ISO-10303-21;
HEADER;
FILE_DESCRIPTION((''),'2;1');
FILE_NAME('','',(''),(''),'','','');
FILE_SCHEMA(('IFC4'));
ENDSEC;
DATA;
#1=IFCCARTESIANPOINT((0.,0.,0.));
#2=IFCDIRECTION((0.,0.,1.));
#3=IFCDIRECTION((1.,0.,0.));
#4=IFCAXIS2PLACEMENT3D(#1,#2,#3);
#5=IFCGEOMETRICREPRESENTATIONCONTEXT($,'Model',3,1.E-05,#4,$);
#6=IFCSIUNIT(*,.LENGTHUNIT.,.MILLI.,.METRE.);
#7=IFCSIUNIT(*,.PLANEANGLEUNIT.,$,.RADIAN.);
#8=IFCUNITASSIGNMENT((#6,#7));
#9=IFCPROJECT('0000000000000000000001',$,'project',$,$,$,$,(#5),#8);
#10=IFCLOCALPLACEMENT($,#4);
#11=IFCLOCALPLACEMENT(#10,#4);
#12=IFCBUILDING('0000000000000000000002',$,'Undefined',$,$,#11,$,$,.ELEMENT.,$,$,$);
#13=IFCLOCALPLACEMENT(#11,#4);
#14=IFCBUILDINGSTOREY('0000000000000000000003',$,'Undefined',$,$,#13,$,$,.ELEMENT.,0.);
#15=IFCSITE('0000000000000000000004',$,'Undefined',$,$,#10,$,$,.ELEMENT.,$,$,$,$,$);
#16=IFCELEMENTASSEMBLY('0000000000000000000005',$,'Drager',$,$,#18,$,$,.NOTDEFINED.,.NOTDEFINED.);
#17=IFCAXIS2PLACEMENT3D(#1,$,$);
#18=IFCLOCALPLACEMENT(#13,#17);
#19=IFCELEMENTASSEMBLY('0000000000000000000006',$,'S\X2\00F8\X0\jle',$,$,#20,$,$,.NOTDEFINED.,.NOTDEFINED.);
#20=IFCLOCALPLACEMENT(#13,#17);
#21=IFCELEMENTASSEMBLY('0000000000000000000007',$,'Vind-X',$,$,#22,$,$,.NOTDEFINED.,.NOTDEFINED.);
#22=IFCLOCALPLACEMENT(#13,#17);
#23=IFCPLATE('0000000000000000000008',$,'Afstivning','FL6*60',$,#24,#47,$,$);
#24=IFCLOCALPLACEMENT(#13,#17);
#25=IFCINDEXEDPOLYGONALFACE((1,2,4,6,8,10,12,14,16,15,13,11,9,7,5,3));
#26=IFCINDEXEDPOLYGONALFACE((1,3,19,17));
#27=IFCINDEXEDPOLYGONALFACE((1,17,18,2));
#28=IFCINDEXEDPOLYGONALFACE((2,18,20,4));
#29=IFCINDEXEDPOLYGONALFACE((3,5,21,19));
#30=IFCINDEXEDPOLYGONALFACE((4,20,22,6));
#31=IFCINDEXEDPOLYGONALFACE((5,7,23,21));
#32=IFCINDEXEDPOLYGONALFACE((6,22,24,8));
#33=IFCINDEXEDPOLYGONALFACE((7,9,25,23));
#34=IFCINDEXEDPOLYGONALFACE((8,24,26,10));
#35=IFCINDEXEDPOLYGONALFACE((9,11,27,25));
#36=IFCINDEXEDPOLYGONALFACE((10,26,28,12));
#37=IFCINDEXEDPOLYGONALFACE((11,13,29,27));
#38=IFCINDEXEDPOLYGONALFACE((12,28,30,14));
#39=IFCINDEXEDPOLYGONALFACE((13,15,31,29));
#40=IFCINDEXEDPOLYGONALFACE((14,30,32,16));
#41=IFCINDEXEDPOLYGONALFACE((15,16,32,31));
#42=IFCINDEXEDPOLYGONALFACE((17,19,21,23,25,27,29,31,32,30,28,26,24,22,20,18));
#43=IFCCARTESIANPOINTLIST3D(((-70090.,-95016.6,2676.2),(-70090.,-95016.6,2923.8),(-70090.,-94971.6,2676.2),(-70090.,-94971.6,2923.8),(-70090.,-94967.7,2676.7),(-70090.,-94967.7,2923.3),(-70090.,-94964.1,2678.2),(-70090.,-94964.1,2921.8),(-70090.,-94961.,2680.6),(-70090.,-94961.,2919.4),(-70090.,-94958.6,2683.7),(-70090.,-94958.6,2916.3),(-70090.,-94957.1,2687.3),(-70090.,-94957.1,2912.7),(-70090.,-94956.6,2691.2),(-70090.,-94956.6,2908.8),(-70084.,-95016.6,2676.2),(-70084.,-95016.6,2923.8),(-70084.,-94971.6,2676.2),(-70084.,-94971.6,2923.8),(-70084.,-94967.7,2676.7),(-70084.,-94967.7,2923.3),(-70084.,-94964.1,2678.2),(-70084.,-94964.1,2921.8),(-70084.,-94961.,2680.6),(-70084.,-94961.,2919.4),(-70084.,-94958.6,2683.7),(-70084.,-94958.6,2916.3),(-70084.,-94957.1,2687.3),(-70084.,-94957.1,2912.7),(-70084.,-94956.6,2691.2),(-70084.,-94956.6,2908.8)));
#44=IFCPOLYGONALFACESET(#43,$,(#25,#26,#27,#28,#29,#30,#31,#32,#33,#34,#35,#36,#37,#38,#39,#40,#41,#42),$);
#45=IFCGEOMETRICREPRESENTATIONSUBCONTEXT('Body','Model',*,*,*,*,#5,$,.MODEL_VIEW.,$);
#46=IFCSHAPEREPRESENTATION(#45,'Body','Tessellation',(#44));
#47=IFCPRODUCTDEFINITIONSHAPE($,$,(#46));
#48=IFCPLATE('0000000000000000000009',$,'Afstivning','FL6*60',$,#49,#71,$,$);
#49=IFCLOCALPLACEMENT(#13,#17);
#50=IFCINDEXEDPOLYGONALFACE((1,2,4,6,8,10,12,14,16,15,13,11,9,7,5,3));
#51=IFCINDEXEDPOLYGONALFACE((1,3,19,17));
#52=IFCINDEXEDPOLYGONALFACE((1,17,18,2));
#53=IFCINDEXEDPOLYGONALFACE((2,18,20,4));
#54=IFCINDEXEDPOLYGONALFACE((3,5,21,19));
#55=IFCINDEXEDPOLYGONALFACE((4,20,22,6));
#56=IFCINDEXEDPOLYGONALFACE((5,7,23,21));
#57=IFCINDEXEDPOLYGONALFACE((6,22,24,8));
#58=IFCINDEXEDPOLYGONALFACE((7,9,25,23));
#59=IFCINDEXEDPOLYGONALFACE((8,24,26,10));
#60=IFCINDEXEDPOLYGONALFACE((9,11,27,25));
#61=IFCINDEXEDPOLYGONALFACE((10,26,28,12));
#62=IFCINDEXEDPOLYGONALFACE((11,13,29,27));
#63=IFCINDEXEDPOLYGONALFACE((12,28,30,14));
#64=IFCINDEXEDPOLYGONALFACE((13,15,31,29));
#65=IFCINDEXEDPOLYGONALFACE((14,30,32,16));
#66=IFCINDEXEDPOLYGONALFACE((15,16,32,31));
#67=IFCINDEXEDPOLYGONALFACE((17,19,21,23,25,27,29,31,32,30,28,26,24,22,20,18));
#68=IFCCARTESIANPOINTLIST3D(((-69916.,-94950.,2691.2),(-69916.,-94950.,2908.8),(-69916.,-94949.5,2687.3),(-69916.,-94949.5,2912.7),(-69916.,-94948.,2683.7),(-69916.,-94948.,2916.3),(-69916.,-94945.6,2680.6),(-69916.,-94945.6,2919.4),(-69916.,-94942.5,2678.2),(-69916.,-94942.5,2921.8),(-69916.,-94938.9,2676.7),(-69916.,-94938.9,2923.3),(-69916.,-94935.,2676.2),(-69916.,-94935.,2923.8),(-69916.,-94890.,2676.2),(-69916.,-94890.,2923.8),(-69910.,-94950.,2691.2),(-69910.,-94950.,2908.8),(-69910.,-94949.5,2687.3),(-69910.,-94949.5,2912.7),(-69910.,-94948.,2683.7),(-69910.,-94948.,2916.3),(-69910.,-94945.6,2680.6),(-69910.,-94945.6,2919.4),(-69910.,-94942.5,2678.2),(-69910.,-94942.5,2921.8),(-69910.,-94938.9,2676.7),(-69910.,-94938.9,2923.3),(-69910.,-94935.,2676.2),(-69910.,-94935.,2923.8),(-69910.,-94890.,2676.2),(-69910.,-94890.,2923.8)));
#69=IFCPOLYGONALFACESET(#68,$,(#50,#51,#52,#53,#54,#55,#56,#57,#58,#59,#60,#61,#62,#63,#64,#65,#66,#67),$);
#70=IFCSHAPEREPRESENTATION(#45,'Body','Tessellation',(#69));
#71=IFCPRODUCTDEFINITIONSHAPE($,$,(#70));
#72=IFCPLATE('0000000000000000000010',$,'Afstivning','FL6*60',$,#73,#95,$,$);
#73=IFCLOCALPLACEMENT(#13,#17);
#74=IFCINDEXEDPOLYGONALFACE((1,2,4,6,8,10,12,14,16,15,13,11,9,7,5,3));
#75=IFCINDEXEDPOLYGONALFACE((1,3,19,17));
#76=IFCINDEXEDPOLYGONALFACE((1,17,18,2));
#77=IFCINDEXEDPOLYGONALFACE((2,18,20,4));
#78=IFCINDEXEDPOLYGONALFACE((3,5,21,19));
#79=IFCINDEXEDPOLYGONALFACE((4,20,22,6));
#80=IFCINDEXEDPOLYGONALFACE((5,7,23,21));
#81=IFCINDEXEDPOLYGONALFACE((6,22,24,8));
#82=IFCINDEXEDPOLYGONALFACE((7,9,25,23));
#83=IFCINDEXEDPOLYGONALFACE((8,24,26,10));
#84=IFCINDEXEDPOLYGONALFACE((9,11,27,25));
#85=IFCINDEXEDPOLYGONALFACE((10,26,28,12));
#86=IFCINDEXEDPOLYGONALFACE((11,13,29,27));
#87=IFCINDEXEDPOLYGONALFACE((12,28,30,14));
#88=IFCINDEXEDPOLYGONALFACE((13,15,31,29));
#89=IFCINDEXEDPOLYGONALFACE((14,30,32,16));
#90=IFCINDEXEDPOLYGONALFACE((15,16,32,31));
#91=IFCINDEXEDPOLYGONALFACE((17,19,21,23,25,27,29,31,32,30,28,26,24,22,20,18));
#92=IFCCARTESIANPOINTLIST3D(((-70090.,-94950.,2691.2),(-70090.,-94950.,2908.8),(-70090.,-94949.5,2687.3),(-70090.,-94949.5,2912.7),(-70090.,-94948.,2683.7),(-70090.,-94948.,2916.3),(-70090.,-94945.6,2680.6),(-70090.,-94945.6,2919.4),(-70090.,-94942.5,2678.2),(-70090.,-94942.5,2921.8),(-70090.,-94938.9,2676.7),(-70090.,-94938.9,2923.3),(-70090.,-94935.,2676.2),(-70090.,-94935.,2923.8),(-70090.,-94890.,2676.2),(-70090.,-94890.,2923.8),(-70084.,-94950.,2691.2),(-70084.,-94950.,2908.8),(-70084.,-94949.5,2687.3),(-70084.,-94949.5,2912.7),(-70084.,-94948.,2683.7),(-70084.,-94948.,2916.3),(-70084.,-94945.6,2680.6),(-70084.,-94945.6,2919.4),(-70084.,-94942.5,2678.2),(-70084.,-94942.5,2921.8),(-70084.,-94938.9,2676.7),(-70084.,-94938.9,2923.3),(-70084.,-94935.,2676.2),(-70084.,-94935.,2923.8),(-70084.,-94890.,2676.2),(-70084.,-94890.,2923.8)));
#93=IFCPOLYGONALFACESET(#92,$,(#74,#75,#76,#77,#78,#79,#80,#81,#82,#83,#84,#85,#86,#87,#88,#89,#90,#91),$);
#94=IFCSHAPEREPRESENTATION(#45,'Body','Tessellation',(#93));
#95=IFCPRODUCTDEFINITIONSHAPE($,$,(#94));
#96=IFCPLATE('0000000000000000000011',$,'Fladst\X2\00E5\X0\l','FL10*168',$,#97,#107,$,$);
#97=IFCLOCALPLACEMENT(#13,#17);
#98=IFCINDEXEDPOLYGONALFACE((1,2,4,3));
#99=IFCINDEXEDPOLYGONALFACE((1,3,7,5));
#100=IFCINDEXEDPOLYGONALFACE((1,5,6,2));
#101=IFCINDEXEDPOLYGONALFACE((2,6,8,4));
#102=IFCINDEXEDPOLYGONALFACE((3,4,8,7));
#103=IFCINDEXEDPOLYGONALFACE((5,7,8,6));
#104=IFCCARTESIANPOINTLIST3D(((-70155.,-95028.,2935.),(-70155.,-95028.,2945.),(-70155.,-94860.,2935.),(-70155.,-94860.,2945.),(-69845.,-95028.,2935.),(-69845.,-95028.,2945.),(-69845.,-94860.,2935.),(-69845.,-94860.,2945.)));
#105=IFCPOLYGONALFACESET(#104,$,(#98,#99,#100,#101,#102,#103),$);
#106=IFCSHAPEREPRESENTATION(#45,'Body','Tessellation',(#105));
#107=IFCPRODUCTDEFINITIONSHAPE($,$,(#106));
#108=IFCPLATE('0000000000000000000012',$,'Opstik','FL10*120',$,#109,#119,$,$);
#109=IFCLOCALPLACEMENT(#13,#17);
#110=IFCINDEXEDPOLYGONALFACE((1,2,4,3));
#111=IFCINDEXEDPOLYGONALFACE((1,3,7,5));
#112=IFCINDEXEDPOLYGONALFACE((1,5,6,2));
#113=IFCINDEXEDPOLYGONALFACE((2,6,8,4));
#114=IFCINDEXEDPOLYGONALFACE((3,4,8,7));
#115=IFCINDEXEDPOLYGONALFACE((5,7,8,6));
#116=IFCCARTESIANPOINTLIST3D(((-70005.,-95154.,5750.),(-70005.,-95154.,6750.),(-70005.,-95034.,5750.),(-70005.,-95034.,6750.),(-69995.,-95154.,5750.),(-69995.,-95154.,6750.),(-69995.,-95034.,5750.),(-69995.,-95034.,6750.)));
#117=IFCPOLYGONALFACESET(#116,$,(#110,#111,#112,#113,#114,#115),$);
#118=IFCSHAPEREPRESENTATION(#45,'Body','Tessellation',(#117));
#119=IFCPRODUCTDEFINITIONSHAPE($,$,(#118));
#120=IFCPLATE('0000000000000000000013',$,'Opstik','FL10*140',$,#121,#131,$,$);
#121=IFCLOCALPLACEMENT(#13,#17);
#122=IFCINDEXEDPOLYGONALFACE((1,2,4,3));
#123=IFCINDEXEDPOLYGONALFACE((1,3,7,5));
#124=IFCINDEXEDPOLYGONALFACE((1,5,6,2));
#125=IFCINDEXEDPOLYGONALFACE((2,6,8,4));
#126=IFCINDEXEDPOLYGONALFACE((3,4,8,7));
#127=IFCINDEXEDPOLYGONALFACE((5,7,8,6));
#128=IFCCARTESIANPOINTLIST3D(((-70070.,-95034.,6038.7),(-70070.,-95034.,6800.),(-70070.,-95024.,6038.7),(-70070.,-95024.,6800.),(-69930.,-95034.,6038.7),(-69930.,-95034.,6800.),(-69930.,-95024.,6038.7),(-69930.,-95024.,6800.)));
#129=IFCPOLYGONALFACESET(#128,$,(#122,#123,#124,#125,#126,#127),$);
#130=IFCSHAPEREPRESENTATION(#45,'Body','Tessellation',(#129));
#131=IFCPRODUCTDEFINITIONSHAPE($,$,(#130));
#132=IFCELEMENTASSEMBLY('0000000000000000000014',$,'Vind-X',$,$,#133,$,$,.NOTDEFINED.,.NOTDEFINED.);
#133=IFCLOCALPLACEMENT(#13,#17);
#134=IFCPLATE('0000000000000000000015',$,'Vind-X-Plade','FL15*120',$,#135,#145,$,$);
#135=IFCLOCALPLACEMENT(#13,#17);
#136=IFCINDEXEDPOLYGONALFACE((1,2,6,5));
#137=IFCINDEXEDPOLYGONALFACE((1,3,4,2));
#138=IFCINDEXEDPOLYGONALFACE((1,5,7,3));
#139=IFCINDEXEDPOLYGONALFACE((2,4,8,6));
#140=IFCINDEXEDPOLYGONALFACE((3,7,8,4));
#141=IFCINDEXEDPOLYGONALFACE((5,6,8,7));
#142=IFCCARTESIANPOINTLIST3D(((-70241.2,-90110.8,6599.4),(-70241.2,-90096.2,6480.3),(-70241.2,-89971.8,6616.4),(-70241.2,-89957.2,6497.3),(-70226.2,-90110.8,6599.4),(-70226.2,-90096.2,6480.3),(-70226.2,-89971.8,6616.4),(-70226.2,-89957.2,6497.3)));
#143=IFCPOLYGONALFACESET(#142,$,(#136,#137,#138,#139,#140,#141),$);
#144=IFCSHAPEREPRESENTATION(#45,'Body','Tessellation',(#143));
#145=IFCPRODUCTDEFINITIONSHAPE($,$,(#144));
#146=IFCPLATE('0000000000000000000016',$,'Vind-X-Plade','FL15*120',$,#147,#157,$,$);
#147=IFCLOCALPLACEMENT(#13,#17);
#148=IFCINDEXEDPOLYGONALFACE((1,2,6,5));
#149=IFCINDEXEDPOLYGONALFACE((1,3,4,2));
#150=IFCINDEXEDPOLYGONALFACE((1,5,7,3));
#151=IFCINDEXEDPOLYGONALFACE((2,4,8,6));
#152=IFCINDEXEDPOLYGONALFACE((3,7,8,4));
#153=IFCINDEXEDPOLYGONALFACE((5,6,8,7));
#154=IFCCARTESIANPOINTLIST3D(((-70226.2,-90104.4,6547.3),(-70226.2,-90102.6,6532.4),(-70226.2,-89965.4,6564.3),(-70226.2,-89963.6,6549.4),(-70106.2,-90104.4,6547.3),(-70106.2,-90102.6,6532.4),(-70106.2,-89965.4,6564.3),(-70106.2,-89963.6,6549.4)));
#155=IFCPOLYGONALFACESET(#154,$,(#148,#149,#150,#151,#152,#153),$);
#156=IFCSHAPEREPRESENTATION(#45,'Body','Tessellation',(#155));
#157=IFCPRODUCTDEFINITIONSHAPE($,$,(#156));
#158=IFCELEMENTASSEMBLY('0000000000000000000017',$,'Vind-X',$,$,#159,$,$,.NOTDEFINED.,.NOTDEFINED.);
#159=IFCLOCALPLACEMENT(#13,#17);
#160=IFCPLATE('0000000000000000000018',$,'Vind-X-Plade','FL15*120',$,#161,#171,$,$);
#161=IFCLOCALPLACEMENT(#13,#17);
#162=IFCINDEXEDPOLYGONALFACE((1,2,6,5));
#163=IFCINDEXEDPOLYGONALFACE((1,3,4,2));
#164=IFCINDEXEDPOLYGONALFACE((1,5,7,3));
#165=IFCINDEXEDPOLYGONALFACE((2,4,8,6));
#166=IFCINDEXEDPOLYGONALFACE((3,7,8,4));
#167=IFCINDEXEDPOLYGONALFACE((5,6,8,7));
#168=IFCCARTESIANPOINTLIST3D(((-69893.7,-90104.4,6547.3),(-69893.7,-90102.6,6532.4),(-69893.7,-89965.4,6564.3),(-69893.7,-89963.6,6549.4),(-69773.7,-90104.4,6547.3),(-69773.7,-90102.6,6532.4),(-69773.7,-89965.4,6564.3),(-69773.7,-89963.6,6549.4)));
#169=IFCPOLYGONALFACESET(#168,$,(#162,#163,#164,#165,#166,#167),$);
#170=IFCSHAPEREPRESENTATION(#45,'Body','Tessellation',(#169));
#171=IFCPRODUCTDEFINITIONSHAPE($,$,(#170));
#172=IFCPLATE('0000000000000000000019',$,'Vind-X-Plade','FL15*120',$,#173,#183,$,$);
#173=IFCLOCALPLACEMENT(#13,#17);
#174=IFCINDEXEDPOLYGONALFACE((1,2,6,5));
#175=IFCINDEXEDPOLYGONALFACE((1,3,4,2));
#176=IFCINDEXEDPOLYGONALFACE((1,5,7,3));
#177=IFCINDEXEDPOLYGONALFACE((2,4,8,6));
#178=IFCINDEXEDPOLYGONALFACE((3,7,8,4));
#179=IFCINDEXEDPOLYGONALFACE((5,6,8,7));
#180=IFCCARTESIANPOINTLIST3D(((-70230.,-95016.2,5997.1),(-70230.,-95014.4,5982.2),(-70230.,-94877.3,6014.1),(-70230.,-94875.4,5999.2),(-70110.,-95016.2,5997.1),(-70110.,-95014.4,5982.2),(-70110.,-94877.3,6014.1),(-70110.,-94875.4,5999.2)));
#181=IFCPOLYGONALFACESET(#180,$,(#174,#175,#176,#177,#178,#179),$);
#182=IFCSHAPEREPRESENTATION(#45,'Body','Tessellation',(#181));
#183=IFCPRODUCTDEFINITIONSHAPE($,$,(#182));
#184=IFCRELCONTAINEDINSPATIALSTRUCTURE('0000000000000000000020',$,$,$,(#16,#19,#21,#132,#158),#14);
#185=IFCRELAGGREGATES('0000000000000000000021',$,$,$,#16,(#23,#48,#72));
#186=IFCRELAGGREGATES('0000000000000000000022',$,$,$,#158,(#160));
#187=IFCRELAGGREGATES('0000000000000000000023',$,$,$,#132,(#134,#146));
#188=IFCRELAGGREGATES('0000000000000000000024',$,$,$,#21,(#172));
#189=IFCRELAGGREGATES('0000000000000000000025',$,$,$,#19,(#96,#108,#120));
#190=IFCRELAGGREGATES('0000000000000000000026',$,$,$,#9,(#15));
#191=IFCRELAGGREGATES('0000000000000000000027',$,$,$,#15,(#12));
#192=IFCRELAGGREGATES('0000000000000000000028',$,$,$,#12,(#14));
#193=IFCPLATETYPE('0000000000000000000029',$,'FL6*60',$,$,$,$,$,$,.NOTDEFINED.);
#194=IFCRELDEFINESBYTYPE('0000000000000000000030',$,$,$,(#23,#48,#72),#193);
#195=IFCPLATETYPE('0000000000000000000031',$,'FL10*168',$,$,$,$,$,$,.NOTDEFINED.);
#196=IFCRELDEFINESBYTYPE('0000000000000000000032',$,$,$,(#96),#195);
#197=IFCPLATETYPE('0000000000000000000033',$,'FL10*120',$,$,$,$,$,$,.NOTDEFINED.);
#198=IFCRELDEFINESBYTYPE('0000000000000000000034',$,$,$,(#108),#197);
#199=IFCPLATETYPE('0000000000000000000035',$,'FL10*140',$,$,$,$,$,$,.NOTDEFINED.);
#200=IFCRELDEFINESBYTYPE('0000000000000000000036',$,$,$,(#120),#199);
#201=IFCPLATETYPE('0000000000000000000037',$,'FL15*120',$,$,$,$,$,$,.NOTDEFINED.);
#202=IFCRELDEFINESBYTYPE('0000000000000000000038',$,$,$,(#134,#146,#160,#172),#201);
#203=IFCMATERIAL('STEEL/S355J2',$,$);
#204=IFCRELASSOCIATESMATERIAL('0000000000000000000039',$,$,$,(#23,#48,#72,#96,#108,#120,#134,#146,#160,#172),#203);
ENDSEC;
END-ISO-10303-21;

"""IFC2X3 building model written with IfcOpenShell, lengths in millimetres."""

from ifc_helpers import new_model, si_unit, frame, frame_2d, origin_with_axes, place, context, subcontext, project, spatial, polyline, circle_curve, parameter, trimmed, segment, composite_curve, outline, extrude, material, type_object, element, aggregate, save


model = new_model("IFC2X3")

# Units and contexts
model_context = context("Model", 3, precision=1e-05, world=origin_with_axes())
body_context = subcontext(model_context, "Body", "Model", "MODEL_VIEW")
ifc_project = project(units=[si_unit("LENGTHUNIT", "METRE", prefix="MILLI"), si_unit("PLANEANGLEUNIT", "RADIAN")], contexts=[model_context])

# Site, building, storey
site_placement = place(None, origin_with_axes())
site = spatial("IfcSite", under=ifc_project, at=site_placement, Name="Undefined", CompositionType="ELEMENT")
building_placement = place(site_placement, origin_with_axes())
building = spatial("IfcBuilding", under=site, at=building_placement, Name="Undefined", CompositionType="ELEMENT")
storey_placement = place(building_placement, origin_with_axes())
storey = spatial("IfcBuildingStorey", under=building, at=storey_placement, Name="Undefined", CompositionType="ELEMENT", Elevation=0.0)

# Element assemblies
assembly_1_placement = place(storey_placement, origin_with_axes())
assembly_1 = element("IfcElementAssembly", 1, at=assembly_1_placement, inside=storey, Name="Drager", AssemblyPlace="NOTDEFINED", PredefinedType="NOTDEFINED")
assembly_2_placement = place(storey_placement, origin_with_axes())
assembly_2 = element("IfcElementAssembly", 2, at=assembly_2_placement, inside=storey, Name="Søjle", AssemblyPlace="NOTDEFINED", PredefinedType="NOTDEFINED")

# Shared definitions
ifc_material_1 = material(Name="STEEL/S355J2")

# Element assembly
assembly_3_placement = place(storey_placement, origin_with_axes())
assembly_3 = element("IfcElementAssembly", 3, at=assembly_3_placement, inside=storey, Name="Vind-X", AssemblyPlace="NOTDEFINED", PredefinedType="NOTDEFINED")

# Plates
plate_type_1 = type_object("IfcPlateType", Name="FL6*60", PredefinedType="NOTDEFINED")
plate_1_placement = place(assembly_1_placement, frame((-70087.0, -94956.6, 2923.8), z_axis=(1.0, 0.0, 0.0), x_axis=(0.0, -1.0, 0.0)))
plate_1 = element("IfcPlate", 4, at=plate_1_placement, type_object=plate_type_1, material=ifc_material_1, Name="Afstivning", Description="FL6*60", context=body_context, shape_type="SweptSolid", body=[
    extrude(outline(composite_curve([segment(trimmed(circle_curve(frame_2d((15.0, 15.0), x_axis=(-1.0, 0.0)), 15.0), [parameter(0.0)], [parameter(1.570796)], True, "PARAMETER"), True, "CONTINUOUS"), segment(polyline([(15.0, 0.0), (60.0, 0.0), (60.0, 247.6), (15.0, 247.6)]), True, "CONTINUOUS"), segment(trimmed(circle_curve(frame_2d((15.0, 232.6), x_axis=(0.0, 1.0)), 15.0), [parameter(0.0)], [parameter(1.570796)], True, "PARAMETER"), True, "CONTINUOUS"), segment(polyline([(0.0, 232.6), (0.0, 15.0)]), True, "CONTINUOUS")], self_intersect=True)), frame((0.0, 0.0, -3.0), z_axis=(0.0, 0.0, 1.0), x_axis=(1.0, 0.0, 0.0)), (0.0, 0.0, 1.0), 6.0),
])
plate_2_placement = place(assembly_1_placement, frame((-69913.0, -94890.0, 2923.8), z_axis=(1.0, 0.0, 0.0), x_axis=(0.0, -1.0, 0.0)))
plate_2 = element("IfcPlate", 5, at=plate_2_placement, type_object=plate_type_1, material=ifc_material_1, Name="Afstivning", Description="FL6*60", context=body_context, shape_type="SweptSolid", body=[
    extrude(outline(composite_curve([segment(polyline([(0.0, 0.0), (45.0, 0.0)]), True, "CONTINUOUS"), segment(trimmed(circle_curve(frame_2d((45.0, 15.0), x_axis=(0.0, -1.0)), 15.0), [parameter(0.0)], [parameter(1.570796)], True, "PARAMETER"), True, "CONTINUOUS"), segment(polyline([(60.0, 15.0), (60.0, 232.6)]), True, "CONTINUOUS"), segment(trimmed(circle_curve(frame_2d((45.0, 232.6), x_axis=(1.0, 0.0)), 15.0), [parameter(0.0)], [parameter(1.570796)], True, "PARAMETER"), True, "CONTINUOUS"), segment(polyline([(45.0, 247.6), (0.0, 247.6), (0.0, 0.0)]), True, "CONTINUOUS")], self_intersect=True)), frame((0.0, 0.0, -3.0), z_axis=(0.0, 0.0, 1.0), x_axis=(1.0, 0.0, 0.0)), (0.0, 0.0, 1.0), 6.0),
])
plate_3_placement = place(assembly_1_placement, frame((-70087.0, -94890.0, 2923.8), z_axis=(1.0, 0.0, 0.0), x_axis=(0.0, -1.0, 0.0)))
plate_3 = element("IfcPlate", 6, at=plate_3_placement, type_object=plate_type_1, material=ifc_material_1, Name="Afstivning", Description="FL6*60", context=body_context, shape_type="SweptSolid", body=[
    extrude(outline(composite_curve([segment(polyline([(0.0, 0.0), (45.0, 0.0)]), True, "CONTINUOUS"), segment(trimmed(circle_curve(frame_2d((45.0, 15.0), x_axis=(0.0, -1.0)), 15.0), [parameter(0.0)], [parameter(1.570796)], True, "PARAMETER"), True, "CONTINUOUS"), segment(polyline([(60.0, 15.0), (60.0, 232.6)]), True, "CONTINUOUS"), segment(trimmed(circle_curve(frame_2d((45.0, 232.6), x_axis=(1.0, 0.0)), 15.0), [parameter(0.0)], [parameter(1.570796)], True, "PARAMETER"), True, "CONTINUOUS"), segment(polyline([(45.0, 247.6), (0.0, 247.6), (0.0, 0.0)]), True, "CONTINUOUS")], self_intersect=True)), frame((0.0, 0.0, -3.0), z_axis=(0.0, 0.0, 1.0), x_axis=(1.0, 0.0, 0.0)), (0.0, 0.0, 1.0), 6.0),
])
aggregate(assembly_1, [plate_1, plate_2, plate_3])
plate_type_2 = type_object("IfcPlateType", Name="FL10*168", PredefinedType="NOTDEFINED")
plate_4_placement = place(assembly_2_placement, frame((-70000.0, -95028.0, 2940.0), z_axis=(0.0, 0.0, 1.0), x_axis=(0.0, 1.0, 0.0)))
plate_4 = element("IfcPlate", 7, at=plate_4_placement, type_object=plate_type_2, material=ifc_material_1, Name="Fladstål", Description="FL10*168", context=body_context, shape_type="SweptSolid", body=[
    extrude(outline(polyline([(0.0, -155.0), (0.0, 155.0), (168.0, 155.0), (168.0, -155.0), (0.0, -155.0)])), frame((0.0, 0.0, -5.0), z_axis=(0.0, 0.0, 1.0), x_axis=(1.0, 0.0, 0.0)), (0.0, 0.0, 1.0), 10.0),
])
plate_type_3 = type_object("IfcPlateType", Name="FL10*120", PredefinedType="NOTDEFINED")
plate_5_placement = place(assembly_2_placement, frame((-70000.0, -95034.0, 5750.0), z_axis=(1.0, 0.0, 0.0), x_axis=(0.0, 0.0, 1.0)))
plate_5 = element("IfcPlate", 8, at=plate_5_placement, type_object=plate_type_3, material=ifc_material_1, Name="Opstik", Description="FL10*120", context=body_context, shape_type="SweptSolid", body=[
    extrude(outline(polyline([(0.0, 0.0), (1000.0, 0.0), (1000.0, 120.0), (1000.0, 120.0), (0.0, 120.0), (0.0, 120.0), (0.0, 0.0)])), frame((0.0, 0.0, -5.0), z_axis=(0.0, 0.0, 1.0), x_axis=(1.0, 0.0, 0.0)), (0.0, 0.0, 1.0), 10.0),
])
plate_type_4 = type_object("IfcPlateType", Name="FL10*140", PredefinedType="NOTDEFINED")
plate_6_placement = place(assembly_2_placement, frame((-69930.0, -95029.0, 6038.7), z_axis=(0.0, -1.0, 0.0), x_axis=(0.0, 0.0, 1.0)))
plate_6 = element("IfcPlate", 9, at=plate_6_placement, type_object=plate_type_4, material=ifc_material_1, Name="Opstik", Description="FL10*140", context=body_context, shape_type="SweptSolid", body=[
    extrude(outline(polyline([(0.0, 0.0), (761.3, 0.0), (761.3, 0.0), (761.3, 140.0), (761.3, 140.0), (0.0, 140.0), (0.0, 0.0)])), frame((0.0, 0.0, -5.0), z_axis=(0.0, 0.0, 1.0), x_axis=(1.0, 0.0, 0.0)), (0.0, 0.0, 1.0), 10.0),
])

# Element assembly, plates
assembly_4_placement = place(storey_placement, origin_with_axes())
assembly_4 = element("IfcElementAssembly", 10, at=assembly_4_placement, inside=storey, Name="Vind-X", AssemblyPlace="NOTDEFINED", PredefinedType="NOTDEFINED")
plate_type_5 = type_object("IfcPlateType", Name="FL15*120", PredefinedType="NOTDEFINED")
plate_7_placement = place(assembly_4_placement, frame((-70233.7, -90096.2, 6480.3), z_axis=(1.0, 0.0, 0.0), x_axis=(0.0, 0.992546, 0.121869)))
plate_7 = element("IfcPlate", 11, at=plate_7_placement, type_object=plate_type_5, material=ifc_material_1, Name="Vind-X-Plade", Description="FL15*120", context=body_context, shape_type="SweptSolid", body=[
    extrude(outline(polyline([(0.0, 0.0), (140.0, 0.0), (140.0, 120.0), (0.0, 120.0), (0.0, 0.0)])), frame((0.0, 0.0, -7.5), z_axis=(0.0, 0.0, 1.0), x_axis=(1.0, 0.0, 0.0)), (0.0, 0.0, 1.0), 15.0),
])
plate_8_placement = place(assembly_4_placement, frame((-70106.2, -90034.0, 6548.4), z_axis=(0.0, 0.121869, -0.992546), x_axis=(-1.0, 0.0, 0.0)))
plate_8 = element("IfcPlate", 12, at=plate_8_placement, type_object=plate_type_5, material=ifc_material_1, Name="Vind-X-Plade", Description="FL15*120", context=body_context, shape_type="SweptSolid", body=[
    extrude(outline(polyline([(0.0, -70.0), (0.0, 70.0), (120.0, 70.0), (120.0, -70.0), (0.0, -70.0)])), frame((0.0, 0.0, -7.5), z_axis=(0.0, 0.0, 1.0), x_axis=(1.0, 0.0, 0.0)), (0.0, 0.0, 1.0), 15.0),
])

# Element assembly, plate
assembly_5_placement = place(storey_placement, origin_with_axes())
assembly_5 = element("IfcElementAssembly", 13, at=assembly_5_placement, inside=storey, Name="Vind-X", AssemblyPlace="NOTDEFINED", PredefinedType="NOTDEFINED")
plate_9_placement = place(assembly_5_placement, frame((-69893.7, -90034.0, 6548.4), z_axis=(0.0, 0.121869, -0.992546), x_axis=(1.0, 0.0, 0.0)))
plate_9 = element("IfcPlate", 14, at=plate_9_placement, type_object=plate_type_5, material=ifc_material_1, Name="Vind-X-Plade", Description="FL15*120", context=body_context, shape_type="SweptSolid", body=[
    extrude(outline(polyline([(0.0, -70.0), (0.0, 70.0), (120.0, 70.0), (120.0, -70.0), (0.0, -70.0)])), frame((0.0, 0.0, -7.5), z_axis=(0.0, 0.0, 1.0), x_axis=(1.0, 0.0, 0.0)), (0.0, 0.0, 1.0), 15.0),
])
aggregate(assembly_5, [plate_9])

# Plate
plate_10_placement = place(assembly_3_placement, frame((-70110.0, -94945.8, 5998.2), z_axis=(0.0, 0.121869, -0.992546), x_axis=(-1.0, 0.0, 0.0)))
plate_10 = element("IfcPlate", 15, at=plate_10_placement, type_object=plate_type_5, material=ifc_material_1, Name="Vind-X-Plade", Description="FL15*120", context=body_context, shape_type="SweptSolid", body=[
    extrude(outline(polyline([(0.0, -70.0), (0.0, 70.0), (120.0, 70.0), (120.0, -70.0), (0.0, -70.0)])), frame((0.0, 0.0, -7.5), z_axis=(0.0, 0.0, 1.0), x_axis=(1.0, 0.0, 0.0)), (0.0, 0.0, 1.0), 15.0),
])

aggregate(assembly_4, [plate_7, plate_8])
aggregate(assembly_3, [plate_10])
aggregate(assembly_2, [plate_4, plate_5, plate_6])

save(model, "model.ifc")
